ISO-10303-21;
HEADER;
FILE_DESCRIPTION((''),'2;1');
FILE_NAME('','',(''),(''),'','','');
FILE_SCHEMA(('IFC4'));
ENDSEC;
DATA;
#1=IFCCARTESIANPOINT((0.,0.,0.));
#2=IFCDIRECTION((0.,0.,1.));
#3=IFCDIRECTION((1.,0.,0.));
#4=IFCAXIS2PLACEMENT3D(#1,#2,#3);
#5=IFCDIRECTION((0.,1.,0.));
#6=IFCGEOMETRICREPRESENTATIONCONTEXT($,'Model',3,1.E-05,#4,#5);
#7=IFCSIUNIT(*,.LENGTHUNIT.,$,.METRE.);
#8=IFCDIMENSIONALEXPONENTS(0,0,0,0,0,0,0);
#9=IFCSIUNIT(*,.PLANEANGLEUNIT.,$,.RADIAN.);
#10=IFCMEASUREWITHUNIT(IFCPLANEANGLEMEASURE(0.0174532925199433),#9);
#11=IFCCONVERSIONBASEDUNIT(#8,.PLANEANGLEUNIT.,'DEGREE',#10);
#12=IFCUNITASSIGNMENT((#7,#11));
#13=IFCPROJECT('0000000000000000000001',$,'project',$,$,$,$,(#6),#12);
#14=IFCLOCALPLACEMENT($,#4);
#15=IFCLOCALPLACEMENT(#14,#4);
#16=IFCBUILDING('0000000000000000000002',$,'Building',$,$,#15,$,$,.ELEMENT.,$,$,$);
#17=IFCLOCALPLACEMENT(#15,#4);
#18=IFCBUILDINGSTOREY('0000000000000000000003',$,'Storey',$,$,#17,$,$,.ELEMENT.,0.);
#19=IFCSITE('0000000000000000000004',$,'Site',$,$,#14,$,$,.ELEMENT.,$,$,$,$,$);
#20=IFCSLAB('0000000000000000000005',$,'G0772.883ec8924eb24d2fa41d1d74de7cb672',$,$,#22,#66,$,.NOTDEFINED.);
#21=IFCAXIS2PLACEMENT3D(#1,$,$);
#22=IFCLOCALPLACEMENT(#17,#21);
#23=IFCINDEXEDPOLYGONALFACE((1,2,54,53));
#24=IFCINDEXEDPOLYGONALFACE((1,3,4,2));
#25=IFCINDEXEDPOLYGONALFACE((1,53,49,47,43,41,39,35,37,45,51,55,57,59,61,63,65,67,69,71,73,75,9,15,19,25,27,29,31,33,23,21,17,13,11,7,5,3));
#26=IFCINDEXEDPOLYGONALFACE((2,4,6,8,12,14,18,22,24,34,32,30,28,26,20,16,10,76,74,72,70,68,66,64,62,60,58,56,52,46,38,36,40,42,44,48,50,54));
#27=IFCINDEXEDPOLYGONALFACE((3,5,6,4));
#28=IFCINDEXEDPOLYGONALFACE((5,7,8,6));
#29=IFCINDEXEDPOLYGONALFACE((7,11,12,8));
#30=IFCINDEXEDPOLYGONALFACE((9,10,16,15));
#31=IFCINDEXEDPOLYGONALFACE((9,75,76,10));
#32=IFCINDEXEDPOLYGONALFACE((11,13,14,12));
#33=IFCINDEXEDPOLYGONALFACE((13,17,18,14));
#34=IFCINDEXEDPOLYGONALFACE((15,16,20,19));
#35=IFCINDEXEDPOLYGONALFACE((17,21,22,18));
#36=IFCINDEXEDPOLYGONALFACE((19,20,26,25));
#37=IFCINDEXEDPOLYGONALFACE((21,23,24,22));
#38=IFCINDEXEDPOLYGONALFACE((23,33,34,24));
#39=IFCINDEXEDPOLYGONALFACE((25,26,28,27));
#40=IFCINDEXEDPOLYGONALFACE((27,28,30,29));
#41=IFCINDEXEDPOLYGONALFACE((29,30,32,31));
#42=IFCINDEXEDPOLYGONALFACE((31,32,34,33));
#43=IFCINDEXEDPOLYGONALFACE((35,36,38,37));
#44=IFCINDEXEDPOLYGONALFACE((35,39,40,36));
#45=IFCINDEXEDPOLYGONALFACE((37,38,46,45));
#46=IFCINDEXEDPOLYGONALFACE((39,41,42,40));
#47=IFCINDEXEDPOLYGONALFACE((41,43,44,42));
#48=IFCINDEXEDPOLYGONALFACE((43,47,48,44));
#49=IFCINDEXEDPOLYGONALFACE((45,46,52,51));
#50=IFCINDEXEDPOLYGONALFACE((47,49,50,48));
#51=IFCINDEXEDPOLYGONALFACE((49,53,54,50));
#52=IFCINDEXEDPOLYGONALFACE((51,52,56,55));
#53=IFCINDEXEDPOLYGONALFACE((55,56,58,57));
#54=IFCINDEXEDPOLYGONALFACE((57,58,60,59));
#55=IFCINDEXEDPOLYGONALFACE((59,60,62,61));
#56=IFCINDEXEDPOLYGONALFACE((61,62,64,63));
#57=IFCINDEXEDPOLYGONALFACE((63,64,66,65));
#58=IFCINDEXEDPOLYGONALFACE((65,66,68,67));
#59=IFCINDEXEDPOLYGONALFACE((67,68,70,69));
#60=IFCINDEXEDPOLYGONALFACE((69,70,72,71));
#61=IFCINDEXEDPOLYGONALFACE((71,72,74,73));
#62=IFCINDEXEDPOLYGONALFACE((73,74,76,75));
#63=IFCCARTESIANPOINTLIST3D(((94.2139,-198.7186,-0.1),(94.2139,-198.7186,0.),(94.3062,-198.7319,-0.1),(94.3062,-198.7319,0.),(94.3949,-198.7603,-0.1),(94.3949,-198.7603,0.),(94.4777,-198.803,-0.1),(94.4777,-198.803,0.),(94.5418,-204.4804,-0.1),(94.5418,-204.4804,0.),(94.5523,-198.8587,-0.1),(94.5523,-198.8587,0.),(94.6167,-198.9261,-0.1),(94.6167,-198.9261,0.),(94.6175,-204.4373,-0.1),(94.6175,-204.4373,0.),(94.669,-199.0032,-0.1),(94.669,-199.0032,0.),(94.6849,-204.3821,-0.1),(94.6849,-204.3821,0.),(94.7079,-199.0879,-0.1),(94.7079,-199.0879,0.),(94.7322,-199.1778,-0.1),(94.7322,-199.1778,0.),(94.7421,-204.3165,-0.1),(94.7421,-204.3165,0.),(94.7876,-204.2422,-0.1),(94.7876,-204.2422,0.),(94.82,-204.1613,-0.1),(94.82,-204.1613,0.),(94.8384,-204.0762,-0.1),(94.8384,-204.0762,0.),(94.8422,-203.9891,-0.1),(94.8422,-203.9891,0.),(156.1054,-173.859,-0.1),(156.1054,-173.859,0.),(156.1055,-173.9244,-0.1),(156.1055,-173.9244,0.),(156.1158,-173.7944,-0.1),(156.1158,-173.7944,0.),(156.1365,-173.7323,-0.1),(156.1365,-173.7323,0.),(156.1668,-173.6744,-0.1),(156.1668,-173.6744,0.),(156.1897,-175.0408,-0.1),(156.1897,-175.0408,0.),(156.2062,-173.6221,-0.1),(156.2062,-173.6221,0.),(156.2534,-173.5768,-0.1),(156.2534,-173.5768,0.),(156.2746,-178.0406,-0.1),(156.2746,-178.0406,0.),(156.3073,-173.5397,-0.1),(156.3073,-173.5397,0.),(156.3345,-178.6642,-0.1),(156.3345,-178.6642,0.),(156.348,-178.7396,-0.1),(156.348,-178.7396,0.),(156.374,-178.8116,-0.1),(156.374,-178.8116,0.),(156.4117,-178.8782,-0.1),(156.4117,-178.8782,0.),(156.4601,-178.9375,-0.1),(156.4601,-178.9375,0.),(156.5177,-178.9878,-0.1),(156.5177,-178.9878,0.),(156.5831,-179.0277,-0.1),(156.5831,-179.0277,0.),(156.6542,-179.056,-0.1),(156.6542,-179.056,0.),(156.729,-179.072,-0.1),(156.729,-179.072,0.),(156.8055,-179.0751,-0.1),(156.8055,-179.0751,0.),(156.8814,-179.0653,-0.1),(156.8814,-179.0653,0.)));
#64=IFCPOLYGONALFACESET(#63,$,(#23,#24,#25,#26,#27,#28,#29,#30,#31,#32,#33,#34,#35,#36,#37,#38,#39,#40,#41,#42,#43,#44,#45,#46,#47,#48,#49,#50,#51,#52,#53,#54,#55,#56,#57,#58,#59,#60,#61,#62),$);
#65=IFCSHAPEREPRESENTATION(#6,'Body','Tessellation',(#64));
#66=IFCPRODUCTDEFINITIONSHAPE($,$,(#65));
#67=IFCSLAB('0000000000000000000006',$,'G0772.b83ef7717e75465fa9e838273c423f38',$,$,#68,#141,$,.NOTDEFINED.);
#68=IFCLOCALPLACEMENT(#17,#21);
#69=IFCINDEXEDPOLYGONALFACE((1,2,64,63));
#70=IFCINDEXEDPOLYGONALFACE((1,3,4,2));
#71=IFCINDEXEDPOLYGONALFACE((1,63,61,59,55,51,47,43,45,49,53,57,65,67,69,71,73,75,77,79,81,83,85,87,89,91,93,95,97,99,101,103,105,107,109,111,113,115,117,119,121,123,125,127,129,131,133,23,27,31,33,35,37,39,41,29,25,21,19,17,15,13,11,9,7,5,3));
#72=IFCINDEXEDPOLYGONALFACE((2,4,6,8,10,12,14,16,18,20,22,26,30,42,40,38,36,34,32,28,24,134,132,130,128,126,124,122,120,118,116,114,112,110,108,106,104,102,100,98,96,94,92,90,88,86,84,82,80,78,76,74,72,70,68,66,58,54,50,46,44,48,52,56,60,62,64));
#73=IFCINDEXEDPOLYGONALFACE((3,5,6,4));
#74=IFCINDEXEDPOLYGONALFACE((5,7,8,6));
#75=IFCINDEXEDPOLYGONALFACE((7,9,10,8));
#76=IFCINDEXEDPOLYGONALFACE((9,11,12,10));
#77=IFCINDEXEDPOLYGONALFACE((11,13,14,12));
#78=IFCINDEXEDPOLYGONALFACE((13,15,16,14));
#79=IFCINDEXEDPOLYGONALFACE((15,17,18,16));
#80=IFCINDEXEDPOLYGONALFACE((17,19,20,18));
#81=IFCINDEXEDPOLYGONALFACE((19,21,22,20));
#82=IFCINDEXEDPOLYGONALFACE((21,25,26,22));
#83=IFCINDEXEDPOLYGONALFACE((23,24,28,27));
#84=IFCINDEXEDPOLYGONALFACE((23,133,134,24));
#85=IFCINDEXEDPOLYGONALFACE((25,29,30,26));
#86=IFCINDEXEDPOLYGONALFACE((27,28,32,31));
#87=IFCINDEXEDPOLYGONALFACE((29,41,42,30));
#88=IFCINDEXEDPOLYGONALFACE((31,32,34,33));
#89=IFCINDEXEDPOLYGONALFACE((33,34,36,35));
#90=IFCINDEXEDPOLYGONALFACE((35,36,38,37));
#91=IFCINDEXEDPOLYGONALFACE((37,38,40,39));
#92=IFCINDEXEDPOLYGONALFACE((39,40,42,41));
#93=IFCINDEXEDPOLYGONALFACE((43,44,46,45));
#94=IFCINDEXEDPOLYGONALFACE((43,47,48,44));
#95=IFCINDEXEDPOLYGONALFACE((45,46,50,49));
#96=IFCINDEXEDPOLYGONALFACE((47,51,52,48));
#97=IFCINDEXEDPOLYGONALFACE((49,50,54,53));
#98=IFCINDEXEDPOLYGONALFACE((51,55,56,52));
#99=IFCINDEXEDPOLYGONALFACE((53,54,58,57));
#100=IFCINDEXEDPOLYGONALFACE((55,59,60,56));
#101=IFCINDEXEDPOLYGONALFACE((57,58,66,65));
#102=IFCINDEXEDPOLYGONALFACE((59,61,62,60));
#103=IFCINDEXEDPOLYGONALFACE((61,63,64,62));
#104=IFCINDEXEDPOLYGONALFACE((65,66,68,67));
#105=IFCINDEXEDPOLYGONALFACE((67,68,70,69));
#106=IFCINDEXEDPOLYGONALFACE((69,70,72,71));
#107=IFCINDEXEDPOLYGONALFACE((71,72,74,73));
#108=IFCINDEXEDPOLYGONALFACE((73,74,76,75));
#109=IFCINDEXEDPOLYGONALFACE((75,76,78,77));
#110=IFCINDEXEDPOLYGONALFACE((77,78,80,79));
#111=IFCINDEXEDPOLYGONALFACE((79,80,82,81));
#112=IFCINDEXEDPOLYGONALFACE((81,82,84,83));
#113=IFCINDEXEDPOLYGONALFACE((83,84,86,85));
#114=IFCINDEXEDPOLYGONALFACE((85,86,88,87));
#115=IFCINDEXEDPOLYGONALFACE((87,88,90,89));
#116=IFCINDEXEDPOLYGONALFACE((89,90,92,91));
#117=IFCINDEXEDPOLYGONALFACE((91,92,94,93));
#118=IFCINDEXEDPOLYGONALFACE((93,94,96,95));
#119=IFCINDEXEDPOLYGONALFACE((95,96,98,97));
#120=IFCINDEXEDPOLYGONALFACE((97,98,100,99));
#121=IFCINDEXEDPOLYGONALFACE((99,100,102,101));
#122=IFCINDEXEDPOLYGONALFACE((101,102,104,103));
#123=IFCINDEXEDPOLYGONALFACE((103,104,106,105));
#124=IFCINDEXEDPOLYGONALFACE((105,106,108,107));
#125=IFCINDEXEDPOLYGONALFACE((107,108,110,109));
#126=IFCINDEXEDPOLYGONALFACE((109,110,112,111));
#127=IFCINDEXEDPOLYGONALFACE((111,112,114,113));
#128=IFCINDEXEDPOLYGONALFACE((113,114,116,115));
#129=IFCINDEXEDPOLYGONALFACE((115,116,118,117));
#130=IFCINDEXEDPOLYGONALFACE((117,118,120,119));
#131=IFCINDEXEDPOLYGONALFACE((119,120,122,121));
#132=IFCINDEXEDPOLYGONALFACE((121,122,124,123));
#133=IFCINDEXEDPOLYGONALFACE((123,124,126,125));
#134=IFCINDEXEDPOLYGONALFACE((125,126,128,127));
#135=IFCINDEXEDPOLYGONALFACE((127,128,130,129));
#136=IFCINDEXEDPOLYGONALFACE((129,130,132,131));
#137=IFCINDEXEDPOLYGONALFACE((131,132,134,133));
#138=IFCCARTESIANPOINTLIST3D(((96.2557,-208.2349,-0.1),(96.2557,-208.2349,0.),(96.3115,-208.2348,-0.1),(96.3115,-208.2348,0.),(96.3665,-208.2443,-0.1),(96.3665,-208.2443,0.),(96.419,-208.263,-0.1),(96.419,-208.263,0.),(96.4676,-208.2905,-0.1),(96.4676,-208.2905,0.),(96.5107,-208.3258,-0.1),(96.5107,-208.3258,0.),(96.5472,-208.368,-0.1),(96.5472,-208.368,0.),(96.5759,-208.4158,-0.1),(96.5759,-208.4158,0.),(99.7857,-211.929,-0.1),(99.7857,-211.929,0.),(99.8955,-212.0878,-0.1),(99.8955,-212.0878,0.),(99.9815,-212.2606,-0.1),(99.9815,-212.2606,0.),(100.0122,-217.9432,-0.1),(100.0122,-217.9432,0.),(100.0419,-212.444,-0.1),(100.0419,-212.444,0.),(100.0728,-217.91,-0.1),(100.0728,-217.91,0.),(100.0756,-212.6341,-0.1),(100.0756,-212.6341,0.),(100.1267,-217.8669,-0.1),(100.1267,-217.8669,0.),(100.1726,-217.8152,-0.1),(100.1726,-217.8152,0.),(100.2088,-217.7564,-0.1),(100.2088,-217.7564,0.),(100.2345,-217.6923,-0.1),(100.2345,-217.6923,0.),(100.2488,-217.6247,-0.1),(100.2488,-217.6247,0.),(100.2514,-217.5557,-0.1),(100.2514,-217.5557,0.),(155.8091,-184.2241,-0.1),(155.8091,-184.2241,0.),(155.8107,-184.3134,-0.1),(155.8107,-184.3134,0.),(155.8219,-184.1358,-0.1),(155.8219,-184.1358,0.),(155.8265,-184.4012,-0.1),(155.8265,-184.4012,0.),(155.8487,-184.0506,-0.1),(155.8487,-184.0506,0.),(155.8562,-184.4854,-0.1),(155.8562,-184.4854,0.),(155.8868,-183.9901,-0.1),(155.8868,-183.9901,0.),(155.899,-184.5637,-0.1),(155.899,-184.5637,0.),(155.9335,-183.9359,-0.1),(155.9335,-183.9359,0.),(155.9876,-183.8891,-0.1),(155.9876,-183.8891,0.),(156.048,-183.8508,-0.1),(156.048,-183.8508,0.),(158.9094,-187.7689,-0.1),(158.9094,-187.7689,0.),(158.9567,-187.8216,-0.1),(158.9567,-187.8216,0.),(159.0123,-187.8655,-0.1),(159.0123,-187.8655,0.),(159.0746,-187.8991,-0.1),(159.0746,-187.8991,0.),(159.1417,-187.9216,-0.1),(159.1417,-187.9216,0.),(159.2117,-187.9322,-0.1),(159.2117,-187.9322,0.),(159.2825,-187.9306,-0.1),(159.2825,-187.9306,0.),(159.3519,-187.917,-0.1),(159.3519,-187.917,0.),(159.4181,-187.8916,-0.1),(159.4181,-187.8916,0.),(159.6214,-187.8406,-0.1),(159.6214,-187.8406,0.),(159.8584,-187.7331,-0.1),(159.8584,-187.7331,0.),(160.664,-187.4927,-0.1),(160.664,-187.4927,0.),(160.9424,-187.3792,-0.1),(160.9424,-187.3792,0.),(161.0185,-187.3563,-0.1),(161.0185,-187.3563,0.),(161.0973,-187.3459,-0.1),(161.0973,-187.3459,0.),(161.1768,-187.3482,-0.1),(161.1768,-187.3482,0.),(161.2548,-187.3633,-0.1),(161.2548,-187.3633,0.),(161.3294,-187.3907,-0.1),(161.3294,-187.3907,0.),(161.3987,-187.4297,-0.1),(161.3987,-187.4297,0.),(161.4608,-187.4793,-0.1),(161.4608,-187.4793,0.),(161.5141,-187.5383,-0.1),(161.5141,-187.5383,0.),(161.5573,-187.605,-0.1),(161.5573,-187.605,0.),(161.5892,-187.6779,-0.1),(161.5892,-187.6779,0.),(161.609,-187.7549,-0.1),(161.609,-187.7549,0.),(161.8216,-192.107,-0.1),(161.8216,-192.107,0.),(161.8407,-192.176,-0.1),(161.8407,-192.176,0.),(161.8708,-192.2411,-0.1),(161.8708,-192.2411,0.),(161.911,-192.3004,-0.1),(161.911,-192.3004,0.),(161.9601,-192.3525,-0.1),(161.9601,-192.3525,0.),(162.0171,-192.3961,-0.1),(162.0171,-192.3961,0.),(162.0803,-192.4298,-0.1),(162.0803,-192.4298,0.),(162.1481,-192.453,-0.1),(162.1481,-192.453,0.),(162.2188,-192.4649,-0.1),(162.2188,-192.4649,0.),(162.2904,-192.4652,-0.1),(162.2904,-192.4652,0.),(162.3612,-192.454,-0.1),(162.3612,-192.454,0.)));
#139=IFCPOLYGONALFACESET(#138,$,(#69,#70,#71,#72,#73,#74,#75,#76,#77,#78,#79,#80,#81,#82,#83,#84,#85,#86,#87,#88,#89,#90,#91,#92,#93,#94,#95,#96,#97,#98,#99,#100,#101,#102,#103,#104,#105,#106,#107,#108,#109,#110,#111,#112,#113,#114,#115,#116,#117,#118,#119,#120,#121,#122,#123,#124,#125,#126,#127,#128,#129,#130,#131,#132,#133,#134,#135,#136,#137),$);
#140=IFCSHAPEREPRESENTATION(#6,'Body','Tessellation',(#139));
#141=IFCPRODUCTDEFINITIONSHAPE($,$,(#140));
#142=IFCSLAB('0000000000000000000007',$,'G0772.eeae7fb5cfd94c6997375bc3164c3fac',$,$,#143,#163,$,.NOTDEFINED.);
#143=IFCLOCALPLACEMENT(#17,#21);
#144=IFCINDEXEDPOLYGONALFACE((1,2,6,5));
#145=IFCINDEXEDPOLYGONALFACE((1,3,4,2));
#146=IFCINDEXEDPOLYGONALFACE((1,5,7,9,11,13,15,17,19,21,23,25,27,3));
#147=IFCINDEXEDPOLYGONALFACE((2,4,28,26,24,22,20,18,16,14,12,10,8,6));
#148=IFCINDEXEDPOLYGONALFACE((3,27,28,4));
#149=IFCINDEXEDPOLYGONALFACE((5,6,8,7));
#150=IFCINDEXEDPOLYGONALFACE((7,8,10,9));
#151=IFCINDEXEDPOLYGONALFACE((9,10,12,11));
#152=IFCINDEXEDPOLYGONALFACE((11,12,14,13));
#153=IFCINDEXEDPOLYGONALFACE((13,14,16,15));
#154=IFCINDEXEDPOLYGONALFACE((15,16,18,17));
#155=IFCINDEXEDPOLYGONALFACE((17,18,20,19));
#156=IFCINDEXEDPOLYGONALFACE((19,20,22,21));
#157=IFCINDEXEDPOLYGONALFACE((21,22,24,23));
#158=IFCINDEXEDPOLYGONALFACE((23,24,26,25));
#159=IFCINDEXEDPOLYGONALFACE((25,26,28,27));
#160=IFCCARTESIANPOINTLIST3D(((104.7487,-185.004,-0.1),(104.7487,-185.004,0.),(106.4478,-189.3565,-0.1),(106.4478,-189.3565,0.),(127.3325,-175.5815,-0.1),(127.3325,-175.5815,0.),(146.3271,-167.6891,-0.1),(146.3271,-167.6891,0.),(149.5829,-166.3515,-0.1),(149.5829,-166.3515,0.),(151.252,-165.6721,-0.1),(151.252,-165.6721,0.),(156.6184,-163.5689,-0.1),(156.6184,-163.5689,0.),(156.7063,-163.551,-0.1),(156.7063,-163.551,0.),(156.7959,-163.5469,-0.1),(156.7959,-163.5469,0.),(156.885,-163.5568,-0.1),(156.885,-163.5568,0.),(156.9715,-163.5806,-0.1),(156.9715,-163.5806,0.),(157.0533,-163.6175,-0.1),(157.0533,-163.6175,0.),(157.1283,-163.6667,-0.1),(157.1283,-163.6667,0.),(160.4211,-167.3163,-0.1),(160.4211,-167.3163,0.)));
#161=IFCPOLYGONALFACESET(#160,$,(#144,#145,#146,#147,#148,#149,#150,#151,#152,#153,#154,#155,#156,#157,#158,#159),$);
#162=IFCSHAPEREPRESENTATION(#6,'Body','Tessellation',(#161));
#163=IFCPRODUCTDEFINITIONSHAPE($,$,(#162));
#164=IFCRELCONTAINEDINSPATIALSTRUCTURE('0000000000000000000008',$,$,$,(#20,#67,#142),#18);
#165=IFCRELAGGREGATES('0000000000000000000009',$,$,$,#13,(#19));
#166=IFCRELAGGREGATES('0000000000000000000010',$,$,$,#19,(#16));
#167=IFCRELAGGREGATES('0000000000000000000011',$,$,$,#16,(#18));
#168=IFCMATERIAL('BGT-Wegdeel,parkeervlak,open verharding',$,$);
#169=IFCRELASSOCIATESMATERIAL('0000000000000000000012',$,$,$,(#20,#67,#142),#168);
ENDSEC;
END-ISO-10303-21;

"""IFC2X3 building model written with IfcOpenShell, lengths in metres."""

from ifc_helpers import new_model, entity, si_unit, converted_unit, direction, frame, origin_with_axes, place, context, project, spatial, polyline, outline, extrude, material, element, save


model = new_model("IFC2X3")

# Units and contexts
model_context = context("Model", 3, precision=1e-05, world=origin_with_axes(), true_north=direction((0.0, 1.0, 0.0)))
ifc_project = project(units=[si_unit("LENGTHUNIT", "METRE"), converted_unit("PLANEANGLEUNIT", "DEGREE", entity("IfcPlaneAngleMeasure", 0.0174532925199433), si_unit("PLANEANGLEUNIT", "RADIAN"), dimensions=[0, 0, 0, 0, 0, 0, 0])], contexts=[model_context])

# Site, building, storey
site_placement = place(None, origin_with_axes())
site = spatial("IfcSite", under=ifc_project, at=site_placement, Name="Site", CompositionType="ELEMENT")
building_placement = place(site_placement, origin_with_axes())
building = spatial("IfcBuilding", under=site, at=building_placement, Name="Building", CompositionType="ELEMENT")
storey_placement = place(building_placement, origin_with_axes())
storey = spatial("IfcBuildingStorey", under=building, at=storey_placement, Name="Storey", CompositionType="ELEMENT", Elevation=0.0)

# Slabs
ifc_material_1 = material(Name="BGT-Wegdeel,parkeervlak,open verharding")
slab_1_placement = place(storey_placement, frame((0.0, 0.0, -0.1), z_axis=(0.0, 0.0, 1.0), x_axis=(1.0, 0.0, 0.0)))
element("IfcSlab", 1, at=slab_1_placement, inside=storey, material=ifc_material_1, Name="G0772.883ec8924eb24d2fa41d1d74de7cb672", PredefinedType="NOTDEFINED", context=model_context, shape_type="SweptSolid", body=[
    extrude(outline(polyline([(156.3073, -173.5397), (156.2534, -173.5768), (156.2062, -173.6221), (156.1668, -173.6744), (156.1365, -173.7323), (156.1158, -173.7944), (156.1054, -173.859), (156.1055, -173.9244), (156.1897, -175.0408), (156.2746, -178.0406), (156.3345, -178.6642), (156.348, -178.7396), (156.374, -178.8116), (156.4117, -178.8782), (156.4601, -178.9375), (156.5177, -178.9878), (156.5831, -179.0277), (156.6542, -179.056), (156.729, -179.072), (156.8055, -179.0751), (156.8814, -179.0653), (94.5418, -204.4804), (94.6175, -204.4373), (94.6849, -204.3821), (94.7421, -204.3165), (94.7876, -204.2422), (94.82, -204.1613), (94.8384, -204.0762), (94.8422, -203.9891), (94.7322, -199.1778), (94.7079, -199.0879), (94.669, -199.0032), (94.6167, -198.9261), (94.5523, -198.8587), (94.4777, -198.803), (94.3949, -198.7603), (94.3062, -198.7319), (94.2139, -198.7186), (156.3073, -173.5397)])), origin_with_axes(), (0.0, 0.0, 1.0), 0.1),
])
slab_2_placement = place(storey_placement, frame((0.0, 0.0, -0.1), z_axis=(0.0, 0.0, 1.0), x_axis=(1.0, 0.0, 0.0)))
element("IfcSlab", 2, at=slab_2_placement, inside=storey, material=ifc_material_1, Name="G0772.b83ef7717e75465fa9e838273c423f38", PredefinedType="NOTDEFINED", context=model_context, shape_type="SweptSolid", body=[
    extrude(outline(polyline([(156.048, -183.8508), (155.9876, -183.8891), (155.9335, -183.9359), (155.8868, -183.9901), (155.8487, -184.0506), (155.8219, -184.1358), (155.8091, -184.2241), (155.8107, -184.3134), (155.8265, -184.4012), (155.8562, -184.4854), (155.899, -184.5637), (158.9094, -187.7689), (158.9567, -187.8216), (159.0123, -187.8655), (159.0746, -187.8991), (159.1417, -187.9216), (159.2117, -187.9322), (159.2825, -187.9306), (159.3519, -187.917), (159.4181, -187.8916), (159.6214, -187.8406), (159.8584, -187.7331), (160.664, -187.4927), (160.9424, -187.3792), (161.0185, -187.3563), (161.0973, -187.3459), (161.1768, -187.3482), (161.2548, -187.3633), (161.3294, -187.3907), (161.3987, -187.4297), (161.4608, -187.4793), (161.5141, -187.5383), (161.5573, -187.605), (161.5892, -187.6779), (161.609, -187.7549), (161.8216, -192.107), (161.8407, -192.176), (161.8708, -192.2411), (161.911, -192.3004), (161.9601, -192.3525), (162.0171, -192.3961), (162.0803, -192.4298), (162.1481, -192.453), (162.2188, -192.4649), (162.2904, -192.4652), (162.3612, -192.454), (100.0122, -217.9432), (100.0728, -217.91), (100.1267, -217.8669), (100.1726, -217.8152), (100.2088, -217.7564), (100.2345, -217.6923), (100.2488, -217.6247), (100.2514, -217.5557), (100.0756, -212.6341), (100.0419, -212.444), (99.9815, -212.2606), (99.8955, -212.0878), (99.7857, -211.929), (96.5759, -208.4158), (96.5472, -208.368), (96.5107, -208.3258), (96.4676, -208.2905), (96.419, -208.263), (96.3665, -208.2443), (96.3115, -208.2348), (96.2557, -208.2349), (156.048, -183.8508)])), origin_with_axes(), (0.0, 0.0, 1.0), 0.1),
])
slab_3_placement = place(storey_placement, frame((0.0, 0.0, -0.1), z_axis=(0.0, 0.0, 1.0), x_axis=(1.0, 0.0, 0.0)))
element("IfcSlab", 3, at=slab_3_placement, inside=storey, material=ifc_material_1, Name="G0772.eeae7fb5cfd94c6997375bc3164c3fac", PredefinedType="NOTDEFINED", context=model_context, shape_type="SweptSolid", body=[
    extrude(outline(polyline([(146.3271, -167.6891), (149.5829, -166.3515), (151.252, -165.6721), (156.6184, -163.5689), (156.7063, -163.551), (156.7959, -163.5469), (156.885, -163.5568), (156.9715, -163.5806), (157.0533, -163.6175), (157.1283, -163.6667), (160.4211, -167.3163), (106.4478, -189.3565), (104.7487, -185.004), (127.3325, -175.5815), (146.3271, -167.6891)])), origin_with_axes(), (0.0, 0.0, 1.0), 0.1),
])

save(model, "model.ifc")
